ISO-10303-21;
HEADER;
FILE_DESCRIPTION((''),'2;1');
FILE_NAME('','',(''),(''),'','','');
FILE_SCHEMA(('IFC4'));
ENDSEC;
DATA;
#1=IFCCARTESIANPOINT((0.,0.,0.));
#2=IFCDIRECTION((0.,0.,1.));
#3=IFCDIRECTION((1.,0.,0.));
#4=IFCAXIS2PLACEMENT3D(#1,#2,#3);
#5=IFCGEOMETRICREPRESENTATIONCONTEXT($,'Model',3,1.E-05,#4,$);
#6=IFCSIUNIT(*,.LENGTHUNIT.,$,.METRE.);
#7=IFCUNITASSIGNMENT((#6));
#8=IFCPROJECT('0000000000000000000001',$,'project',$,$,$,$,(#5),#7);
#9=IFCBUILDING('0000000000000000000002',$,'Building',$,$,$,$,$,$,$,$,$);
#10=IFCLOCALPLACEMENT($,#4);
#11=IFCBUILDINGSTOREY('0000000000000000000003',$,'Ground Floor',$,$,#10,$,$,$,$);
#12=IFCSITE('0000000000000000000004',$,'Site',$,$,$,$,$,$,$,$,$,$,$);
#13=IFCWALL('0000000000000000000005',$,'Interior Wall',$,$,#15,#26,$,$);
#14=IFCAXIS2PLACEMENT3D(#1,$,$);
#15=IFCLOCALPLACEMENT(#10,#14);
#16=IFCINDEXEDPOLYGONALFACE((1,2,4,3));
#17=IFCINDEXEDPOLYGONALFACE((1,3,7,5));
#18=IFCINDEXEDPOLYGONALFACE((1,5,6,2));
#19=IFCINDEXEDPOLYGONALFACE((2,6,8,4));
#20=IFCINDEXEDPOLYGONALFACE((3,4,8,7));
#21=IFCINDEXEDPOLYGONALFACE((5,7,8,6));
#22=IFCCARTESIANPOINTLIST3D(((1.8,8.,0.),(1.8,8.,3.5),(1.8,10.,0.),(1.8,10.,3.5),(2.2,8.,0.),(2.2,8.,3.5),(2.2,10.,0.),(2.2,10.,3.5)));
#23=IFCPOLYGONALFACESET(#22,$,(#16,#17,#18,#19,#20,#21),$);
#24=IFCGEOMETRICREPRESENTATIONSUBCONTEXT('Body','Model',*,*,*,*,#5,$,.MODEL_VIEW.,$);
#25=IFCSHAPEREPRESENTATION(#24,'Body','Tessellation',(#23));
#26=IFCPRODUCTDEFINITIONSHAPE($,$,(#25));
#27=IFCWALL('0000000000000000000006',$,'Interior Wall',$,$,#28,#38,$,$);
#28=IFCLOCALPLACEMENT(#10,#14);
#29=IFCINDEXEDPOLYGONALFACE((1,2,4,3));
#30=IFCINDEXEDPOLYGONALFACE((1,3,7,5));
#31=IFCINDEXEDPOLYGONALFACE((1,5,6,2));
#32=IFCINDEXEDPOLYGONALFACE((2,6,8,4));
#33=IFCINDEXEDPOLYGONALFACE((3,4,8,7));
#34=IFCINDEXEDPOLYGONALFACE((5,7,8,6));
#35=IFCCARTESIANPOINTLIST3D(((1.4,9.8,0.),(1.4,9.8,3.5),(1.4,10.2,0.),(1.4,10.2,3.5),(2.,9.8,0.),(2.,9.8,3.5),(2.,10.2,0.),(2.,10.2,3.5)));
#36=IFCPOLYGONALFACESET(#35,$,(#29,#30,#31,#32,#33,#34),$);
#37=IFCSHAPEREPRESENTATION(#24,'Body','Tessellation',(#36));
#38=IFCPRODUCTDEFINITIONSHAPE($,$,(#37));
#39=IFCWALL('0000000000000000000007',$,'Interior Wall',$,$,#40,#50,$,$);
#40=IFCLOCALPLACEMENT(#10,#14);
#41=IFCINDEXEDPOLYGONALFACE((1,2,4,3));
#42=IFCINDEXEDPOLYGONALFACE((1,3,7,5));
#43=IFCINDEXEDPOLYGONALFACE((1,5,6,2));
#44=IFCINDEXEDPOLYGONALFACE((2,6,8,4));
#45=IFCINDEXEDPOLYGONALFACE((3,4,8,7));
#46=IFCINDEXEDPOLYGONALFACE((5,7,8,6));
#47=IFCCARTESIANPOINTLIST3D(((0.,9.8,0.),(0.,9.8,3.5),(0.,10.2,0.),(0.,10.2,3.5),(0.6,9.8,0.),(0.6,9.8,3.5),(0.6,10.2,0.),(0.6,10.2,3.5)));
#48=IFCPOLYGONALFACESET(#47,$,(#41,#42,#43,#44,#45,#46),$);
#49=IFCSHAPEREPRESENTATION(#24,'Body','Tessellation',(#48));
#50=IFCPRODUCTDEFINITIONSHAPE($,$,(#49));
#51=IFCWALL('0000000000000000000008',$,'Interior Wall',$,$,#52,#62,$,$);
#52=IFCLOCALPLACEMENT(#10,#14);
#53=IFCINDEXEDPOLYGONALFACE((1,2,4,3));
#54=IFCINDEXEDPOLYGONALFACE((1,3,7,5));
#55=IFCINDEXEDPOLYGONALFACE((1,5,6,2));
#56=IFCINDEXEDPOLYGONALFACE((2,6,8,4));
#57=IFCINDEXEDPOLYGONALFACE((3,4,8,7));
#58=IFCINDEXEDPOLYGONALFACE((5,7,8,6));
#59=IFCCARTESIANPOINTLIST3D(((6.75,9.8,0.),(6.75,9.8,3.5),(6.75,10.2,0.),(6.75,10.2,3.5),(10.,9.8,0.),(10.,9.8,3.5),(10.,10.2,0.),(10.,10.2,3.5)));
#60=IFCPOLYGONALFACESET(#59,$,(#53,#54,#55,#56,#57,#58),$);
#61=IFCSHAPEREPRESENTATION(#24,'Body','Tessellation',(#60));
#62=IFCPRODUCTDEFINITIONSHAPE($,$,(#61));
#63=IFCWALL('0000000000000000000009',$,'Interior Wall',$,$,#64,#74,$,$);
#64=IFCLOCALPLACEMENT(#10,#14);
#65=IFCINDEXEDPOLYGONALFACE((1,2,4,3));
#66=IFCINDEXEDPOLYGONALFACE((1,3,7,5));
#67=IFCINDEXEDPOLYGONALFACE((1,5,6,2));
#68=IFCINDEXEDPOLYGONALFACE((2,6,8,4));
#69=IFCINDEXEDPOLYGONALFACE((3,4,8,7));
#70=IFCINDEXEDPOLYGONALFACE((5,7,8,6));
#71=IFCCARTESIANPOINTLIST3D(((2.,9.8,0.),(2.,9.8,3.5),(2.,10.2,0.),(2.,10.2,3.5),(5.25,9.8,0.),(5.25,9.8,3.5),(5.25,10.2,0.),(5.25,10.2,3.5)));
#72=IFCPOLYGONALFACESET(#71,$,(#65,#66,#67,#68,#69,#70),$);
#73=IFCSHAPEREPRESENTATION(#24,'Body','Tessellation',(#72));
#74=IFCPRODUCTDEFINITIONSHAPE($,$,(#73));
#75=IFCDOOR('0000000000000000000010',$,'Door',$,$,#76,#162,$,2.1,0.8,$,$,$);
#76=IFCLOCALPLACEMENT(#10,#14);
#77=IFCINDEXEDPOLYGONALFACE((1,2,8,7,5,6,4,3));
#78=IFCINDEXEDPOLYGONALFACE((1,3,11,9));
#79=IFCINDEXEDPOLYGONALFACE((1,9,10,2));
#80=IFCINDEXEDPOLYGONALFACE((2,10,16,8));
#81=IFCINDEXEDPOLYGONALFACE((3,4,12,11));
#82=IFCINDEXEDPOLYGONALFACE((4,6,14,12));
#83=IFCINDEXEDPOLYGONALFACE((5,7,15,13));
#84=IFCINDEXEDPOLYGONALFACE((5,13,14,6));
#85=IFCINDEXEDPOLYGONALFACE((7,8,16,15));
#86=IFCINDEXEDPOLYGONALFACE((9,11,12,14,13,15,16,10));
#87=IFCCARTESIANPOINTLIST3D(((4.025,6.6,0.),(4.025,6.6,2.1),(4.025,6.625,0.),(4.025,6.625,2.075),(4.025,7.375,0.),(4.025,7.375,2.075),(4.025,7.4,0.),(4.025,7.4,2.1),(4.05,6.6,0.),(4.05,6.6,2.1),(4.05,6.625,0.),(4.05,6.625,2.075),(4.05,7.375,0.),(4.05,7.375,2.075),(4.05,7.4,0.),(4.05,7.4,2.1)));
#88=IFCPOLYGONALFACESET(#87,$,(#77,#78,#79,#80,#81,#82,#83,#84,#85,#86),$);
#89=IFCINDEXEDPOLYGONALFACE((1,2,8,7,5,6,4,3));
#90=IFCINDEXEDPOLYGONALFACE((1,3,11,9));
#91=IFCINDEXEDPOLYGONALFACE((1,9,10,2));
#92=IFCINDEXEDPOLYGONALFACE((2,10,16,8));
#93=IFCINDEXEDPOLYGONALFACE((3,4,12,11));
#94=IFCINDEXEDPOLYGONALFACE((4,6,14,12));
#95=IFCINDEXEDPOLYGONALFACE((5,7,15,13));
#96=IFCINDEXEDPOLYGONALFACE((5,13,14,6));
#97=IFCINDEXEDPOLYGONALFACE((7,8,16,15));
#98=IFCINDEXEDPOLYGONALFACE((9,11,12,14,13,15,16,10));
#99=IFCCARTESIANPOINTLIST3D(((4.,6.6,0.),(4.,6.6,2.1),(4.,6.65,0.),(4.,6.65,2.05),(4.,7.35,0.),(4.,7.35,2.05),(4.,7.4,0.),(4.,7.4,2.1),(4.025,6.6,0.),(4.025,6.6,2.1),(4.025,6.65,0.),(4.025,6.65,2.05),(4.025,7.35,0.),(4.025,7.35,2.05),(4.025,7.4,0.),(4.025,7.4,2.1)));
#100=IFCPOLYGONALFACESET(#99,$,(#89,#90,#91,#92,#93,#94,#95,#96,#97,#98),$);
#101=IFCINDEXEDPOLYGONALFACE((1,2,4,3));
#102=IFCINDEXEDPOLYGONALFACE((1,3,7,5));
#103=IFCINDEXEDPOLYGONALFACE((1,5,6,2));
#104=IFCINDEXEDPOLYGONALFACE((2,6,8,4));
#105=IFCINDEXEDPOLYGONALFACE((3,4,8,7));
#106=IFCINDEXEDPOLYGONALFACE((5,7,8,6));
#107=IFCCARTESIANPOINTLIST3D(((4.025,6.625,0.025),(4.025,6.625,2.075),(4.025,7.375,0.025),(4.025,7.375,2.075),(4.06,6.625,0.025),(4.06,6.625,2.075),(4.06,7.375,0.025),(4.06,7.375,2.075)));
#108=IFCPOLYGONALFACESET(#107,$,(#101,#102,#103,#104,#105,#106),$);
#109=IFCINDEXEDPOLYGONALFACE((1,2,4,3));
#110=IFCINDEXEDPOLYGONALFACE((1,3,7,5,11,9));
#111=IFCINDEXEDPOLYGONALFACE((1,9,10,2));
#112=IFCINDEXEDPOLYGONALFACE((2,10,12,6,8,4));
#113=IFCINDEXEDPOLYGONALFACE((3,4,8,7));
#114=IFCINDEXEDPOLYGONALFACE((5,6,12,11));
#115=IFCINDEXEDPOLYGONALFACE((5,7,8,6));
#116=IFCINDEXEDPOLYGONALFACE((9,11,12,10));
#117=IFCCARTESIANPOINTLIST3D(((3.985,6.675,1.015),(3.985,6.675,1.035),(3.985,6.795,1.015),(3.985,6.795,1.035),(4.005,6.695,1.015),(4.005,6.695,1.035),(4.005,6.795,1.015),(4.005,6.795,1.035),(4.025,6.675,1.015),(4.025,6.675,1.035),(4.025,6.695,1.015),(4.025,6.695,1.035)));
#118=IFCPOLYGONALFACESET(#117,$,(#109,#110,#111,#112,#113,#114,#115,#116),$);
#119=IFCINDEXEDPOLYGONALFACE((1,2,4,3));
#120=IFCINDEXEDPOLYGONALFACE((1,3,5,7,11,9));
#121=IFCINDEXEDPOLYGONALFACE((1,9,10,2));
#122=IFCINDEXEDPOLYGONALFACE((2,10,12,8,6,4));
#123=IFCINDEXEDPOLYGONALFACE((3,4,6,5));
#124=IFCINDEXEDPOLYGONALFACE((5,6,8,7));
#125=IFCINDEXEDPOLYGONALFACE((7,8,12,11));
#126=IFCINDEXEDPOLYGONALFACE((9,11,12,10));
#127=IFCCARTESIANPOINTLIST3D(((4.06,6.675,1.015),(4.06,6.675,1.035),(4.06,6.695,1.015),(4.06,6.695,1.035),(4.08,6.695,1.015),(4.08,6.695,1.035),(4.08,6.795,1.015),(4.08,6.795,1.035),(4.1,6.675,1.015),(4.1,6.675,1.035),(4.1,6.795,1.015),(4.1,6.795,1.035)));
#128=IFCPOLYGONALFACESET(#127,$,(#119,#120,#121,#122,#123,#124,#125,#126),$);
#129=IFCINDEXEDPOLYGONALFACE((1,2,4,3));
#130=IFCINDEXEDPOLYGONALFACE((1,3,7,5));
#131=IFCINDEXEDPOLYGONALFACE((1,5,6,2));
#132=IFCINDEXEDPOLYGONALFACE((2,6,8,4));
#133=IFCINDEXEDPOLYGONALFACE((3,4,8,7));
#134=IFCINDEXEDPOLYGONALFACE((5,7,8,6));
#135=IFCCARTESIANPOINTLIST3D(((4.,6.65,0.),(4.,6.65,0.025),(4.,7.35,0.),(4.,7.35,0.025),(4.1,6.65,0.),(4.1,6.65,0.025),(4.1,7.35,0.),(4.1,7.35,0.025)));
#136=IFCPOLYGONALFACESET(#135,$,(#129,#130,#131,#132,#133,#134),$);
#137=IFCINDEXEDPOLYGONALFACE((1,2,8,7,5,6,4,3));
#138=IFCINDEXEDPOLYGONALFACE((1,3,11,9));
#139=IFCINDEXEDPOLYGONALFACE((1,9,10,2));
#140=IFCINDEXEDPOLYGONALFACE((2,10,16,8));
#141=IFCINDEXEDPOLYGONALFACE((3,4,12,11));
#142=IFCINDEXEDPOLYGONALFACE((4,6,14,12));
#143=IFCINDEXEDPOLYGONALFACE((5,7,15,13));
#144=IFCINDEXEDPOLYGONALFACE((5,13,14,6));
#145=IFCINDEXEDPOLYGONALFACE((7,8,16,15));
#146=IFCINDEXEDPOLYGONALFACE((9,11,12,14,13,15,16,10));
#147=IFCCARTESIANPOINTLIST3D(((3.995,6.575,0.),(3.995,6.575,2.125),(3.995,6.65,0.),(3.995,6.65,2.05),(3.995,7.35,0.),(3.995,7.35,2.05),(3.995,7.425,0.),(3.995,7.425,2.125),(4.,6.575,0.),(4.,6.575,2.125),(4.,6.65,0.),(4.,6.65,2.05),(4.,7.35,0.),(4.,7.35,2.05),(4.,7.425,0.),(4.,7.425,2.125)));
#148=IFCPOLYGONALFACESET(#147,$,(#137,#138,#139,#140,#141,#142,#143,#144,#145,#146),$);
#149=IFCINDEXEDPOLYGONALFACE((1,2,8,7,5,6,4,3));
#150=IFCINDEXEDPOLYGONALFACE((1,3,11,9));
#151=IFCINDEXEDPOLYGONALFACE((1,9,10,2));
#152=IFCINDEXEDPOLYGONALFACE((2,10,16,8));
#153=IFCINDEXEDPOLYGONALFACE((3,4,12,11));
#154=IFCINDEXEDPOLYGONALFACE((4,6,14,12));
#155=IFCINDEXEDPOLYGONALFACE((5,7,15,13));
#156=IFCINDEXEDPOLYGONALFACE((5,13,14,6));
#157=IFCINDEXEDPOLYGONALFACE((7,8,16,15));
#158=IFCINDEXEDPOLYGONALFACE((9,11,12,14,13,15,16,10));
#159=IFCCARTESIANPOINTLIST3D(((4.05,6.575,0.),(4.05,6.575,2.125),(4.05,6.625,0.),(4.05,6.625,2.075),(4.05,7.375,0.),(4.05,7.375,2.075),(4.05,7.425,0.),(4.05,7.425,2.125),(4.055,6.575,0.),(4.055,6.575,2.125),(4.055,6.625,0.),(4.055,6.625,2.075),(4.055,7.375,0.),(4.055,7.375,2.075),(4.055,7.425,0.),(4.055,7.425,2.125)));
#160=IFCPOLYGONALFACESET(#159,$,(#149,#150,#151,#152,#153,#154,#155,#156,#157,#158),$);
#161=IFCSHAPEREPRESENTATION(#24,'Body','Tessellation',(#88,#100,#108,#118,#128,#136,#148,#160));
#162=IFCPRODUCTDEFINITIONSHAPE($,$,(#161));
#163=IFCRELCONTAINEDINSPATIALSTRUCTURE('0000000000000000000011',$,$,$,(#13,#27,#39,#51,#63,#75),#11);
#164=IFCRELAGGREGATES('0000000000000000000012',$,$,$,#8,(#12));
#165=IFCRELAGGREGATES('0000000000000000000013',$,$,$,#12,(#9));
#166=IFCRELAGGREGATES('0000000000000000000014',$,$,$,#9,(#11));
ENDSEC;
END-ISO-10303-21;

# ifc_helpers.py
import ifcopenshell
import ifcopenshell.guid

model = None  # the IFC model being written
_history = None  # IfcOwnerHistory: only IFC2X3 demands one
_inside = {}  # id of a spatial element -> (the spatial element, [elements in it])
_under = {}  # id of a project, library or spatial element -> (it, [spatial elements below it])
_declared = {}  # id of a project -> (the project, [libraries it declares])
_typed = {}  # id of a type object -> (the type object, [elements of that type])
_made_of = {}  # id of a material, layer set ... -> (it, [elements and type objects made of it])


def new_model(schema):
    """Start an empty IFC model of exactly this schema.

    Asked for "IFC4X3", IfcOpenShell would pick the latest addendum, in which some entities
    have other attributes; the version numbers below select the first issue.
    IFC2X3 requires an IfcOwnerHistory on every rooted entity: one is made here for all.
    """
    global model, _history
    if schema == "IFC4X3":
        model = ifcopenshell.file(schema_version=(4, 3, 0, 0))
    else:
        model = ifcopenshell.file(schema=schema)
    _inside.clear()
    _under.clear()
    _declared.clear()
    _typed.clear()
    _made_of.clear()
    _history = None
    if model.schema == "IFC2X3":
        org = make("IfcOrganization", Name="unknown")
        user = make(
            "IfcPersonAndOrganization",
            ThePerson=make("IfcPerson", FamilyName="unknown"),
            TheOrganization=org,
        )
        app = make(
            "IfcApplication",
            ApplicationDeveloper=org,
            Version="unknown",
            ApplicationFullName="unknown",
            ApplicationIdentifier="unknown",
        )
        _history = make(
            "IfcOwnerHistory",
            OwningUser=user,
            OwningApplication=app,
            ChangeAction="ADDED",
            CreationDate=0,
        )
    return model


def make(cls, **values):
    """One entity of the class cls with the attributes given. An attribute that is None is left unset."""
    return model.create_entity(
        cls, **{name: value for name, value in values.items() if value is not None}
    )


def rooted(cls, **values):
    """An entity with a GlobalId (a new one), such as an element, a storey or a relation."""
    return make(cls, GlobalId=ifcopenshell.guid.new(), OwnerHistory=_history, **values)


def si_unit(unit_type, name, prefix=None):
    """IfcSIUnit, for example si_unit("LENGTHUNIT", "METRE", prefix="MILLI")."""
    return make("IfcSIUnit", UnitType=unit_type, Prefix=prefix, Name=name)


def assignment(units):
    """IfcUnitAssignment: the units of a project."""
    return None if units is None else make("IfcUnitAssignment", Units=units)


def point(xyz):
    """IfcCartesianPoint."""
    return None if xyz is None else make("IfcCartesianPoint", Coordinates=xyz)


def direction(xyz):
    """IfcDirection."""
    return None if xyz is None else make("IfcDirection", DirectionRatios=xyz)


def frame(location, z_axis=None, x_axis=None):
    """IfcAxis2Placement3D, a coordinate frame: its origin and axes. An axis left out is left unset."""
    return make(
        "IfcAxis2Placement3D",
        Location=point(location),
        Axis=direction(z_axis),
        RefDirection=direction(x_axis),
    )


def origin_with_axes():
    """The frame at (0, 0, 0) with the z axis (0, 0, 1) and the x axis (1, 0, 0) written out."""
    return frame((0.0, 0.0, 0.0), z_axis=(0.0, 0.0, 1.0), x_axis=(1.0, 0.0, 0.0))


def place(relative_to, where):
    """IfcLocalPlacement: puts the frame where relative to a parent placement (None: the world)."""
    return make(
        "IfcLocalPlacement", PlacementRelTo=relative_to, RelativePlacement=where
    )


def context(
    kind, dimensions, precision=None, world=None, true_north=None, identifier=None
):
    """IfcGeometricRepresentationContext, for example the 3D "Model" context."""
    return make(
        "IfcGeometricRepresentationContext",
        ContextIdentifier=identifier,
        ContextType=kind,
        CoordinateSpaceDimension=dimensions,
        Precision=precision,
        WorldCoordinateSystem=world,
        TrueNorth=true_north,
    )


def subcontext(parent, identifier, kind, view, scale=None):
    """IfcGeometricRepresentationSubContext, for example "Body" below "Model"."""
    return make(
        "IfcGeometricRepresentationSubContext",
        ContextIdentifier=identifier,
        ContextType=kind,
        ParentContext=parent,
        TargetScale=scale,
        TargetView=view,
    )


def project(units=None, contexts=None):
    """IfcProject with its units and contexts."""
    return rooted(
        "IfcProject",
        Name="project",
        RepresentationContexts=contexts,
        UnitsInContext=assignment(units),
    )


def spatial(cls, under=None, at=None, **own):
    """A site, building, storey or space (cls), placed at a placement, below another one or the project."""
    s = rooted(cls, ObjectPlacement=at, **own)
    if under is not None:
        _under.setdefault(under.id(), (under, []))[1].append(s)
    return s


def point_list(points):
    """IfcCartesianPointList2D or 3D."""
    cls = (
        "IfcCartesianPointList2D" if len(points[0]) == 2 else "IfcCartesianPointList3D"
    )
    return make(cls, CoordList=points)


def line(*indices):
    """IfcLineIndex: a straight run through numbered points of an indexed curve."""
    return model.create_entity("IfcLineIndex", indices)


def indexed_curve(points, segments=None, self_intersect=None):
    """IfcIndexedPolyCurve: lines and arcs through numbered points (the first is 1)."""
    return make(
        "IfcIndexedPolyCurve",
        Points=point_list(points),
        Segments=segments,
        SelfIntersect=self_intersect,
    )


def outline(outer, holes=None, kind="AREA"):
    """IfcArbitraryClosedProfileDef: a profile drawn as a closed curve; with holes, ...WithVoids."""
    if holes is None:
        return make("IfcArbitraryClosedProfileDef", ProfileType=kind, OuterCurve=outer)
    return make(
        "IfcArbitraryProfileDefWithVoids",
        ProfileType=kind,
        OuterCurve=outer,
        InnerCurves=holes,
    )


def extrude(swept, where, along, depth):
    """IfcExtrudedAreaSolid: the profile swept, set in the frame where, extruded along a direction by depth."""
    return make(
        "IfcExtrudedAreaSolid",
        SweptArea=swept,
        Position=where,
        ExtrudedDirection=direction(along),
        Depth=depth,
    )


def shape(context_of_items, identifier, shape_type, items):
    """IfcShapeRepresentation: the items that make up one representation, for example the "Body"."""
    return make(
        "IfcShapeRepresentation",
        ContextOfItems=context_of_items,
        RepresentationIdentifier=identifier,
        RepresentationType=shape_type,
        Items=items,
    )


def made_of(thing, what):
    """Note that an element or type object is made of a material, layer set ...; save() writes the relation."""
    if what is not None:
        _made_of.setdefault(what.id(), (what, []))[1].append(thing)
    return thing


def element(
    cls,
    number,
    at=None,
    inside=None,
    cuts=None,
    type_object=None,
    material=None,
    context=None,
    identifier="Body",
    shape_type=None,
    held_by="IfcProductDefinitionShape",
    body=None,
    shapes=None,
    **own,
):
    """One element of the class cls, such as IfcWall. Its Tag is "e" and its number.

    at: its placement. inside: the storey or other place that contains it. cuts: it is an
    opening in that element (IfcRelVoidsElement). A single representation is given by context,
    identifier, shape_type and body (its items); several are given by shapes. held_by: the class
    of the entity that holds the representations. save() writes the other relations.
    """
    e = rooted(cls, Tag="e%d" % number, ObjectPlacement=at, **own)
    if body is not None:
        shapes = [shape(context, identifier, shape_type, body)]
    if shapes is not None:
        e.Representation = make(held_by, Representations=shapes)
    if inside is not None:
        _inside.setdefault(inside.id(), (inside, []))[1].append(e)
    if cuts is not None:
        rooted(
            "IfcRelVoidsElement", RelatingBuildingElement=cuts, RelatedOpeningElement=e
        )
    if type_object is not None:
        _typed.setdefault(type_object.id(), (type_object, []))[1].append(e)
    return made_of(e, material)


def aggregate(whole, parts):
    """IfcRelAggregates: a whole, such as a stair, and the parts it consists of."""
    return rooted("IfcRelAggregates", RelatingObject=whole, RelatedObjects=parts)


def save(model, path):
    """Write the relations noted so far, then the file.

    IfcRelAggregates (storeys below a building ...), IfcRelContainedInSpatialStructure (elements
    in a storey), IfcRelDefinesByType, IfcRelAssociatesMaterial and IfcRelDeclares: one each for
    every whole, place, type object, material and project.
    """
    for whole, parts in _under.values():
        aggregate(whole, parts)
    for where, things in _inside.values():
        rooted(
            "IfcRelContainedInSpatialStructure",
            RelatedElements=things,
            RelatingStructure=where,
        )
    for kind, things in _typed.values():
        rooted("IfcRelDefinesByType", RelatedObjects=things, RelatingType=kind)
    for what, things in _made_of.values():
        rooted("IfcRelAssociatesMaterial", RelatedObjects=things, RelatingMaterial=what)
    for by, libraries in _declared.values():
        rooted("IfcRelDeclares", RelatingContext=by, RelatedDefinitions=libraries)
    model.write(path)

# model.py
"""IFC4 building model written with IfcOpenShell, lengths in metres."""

from ifc_helpers import new_model, si_unit, frame, origin_with_axes, place, context, subcontext, project, spatial, line, indexed_curve, outline, extrude, element, save


model = new_model("IFC4")

# Units and contexts
model_context = context("Model", 3, precision=1e-05, world=origin_with_axes())
body_context = subcontext(model_context, "Body", "Model", "MODEL_VIEW")
ifc_project = project(units=[si_unit("LENGTHUNIT", "METRE")], contexts=[model_context])

# Site, building, storey
site = spatial("IfcSite", under=ifc_project, Name="Site")
building = spatial("IfcBuilding", under=site, Name="Building")
storey_placement = place(None, origin_with_axes())
storey = spatial("IfcBuildingStorey", under=building, at=storey_placement, Name="Ground Floor")

# Walls
wall_1_placement = place(storey_placement, frame((2.0, 8.0, 0.0), z_axis=(0.0, 0.0, 1.0), x_axis=(0.0, 1.0, 0.0)))
element("IfcWall", 1, at=wall_1_placement, inside=storey, Name="Interior Wall", context=body_context, shape_type="SweptSolid", body=[
    extrude(outline(indexed_curve([(0.0, 0.0), (0.0, 0.4), (2.0, 0.4), (2.0, 0.0), (0.0, 0.0)], self_intersect=False)), frame((0.0, -0.2, 0.0), z_axis=(0.0, 0.0, 1.0), x_axis=(1.0, 0.0, 0.0)), (0.0, 0.0, 1.0), 3.5),
])
for number, where, z_axis, x_axis, name in (
    (2, (2.0, 10.0, 0.0), (0.0, 0.0, 1.0), (-1.0, 0.0, 0.0), "Interior Wall"),
    (3, (0.6, 10.0, 0.0), (0.0, 0.0, 1.0), (-1.0, 0.0, 0.0), "Interior Wall"),
):
    element("IfcWall", number, at=place(storey_placement, frame(where, z_axis=z_axis, x_axis=x_axis)), inside=storey, Name=name, context=body_context, shape_type="SweptSolid", body=[
        extrude(outline(indexed_curve([(0.0, 0.0), (0.0, 0.4), (0.6, 0.4), (0.6, 0.0), (0.0, 0.0)], self_intersect=False)), frame((0.0, -0.2, 0.0), z_axis=(0.0, 0.0, 1.0), x_axis=(1.0, 0.0, 0.0)), (0.0, 0.0, 1.0), 3.5),
    ])
for number, where, z_axis, x_axis, name in (
    (4, (10.0, 10.0, 0.0), (0.0, 0.0, 1.0), (-1.0, 0.0, 0.0), "Interior Wall"),
    (5, (5.25, 10.0, 0.0), (0.0, 0.0, 1.0), (-1.0, 0.0, 0.0), "Interior Wall"),
):
    element("IfcWall", number, at=place(storey_placement, frame(where, z_axis=z_axis, x_axis=x_axis)), inside=storey, Name=name, context=body_context, shape_type="SweptSolid", body=[
        extrude(outline(indexed_curve([(0.0, 0.0), (0.0, 0.4), (3.25, 0.4), (3.25, 0.0), (0.0, 0.0)], self_intersect=False)), frame((0.0, -0.2, 0.0), z_axis=(0.0, 0.0, 1.0), x_axis=(1.0, 0.0, 0.0)), (0.0, 0.0, 1.0), 3.5),
    ])

# Door
door_1_placement = place(storey_placement, frame((4.0, 7.4, 0.0), z_axis=(0.0, 0.0, 1.0), x_axis=(0.0, -1.0, 0.0)))
element("IfcDoor", 6, at=door_1_placement, inside=storey, Name="Door", OverallHeight=2.1, OverallWidth=0.8, context=body_context, shape_type="SweptSolid", body=[
    extrude(outline(indexed_curve([(0.0, 0.0), (0.0, 2.1), (0.8, 2.1), (0.8, 0.0), (0.775, 0.0), (0.775, 2.075), (0.025, 2.075), (0.025, 0.0)], segments=[line(1, 2, 3, 4, 5, 6, 7, 8, 1)])), frame((0.0, 0.025, 0.0), z_axis=(0.0, -1.0, 0.0), x_axis=(1.0, 0.0, 0.0)), (0.0, 0.0, -1.0), 0.025),
    extrude(outline(indexed_curve([(0.0, 0.0), (0.0, 2.1), (0.8, 2.1), (0.8, 0.0), (0.75, 0.0), (0.75, 2.05), (0.05, 2.05), (0.05, 0.0)], segments=[line(1, 2, 3, 4, 5, 6, 7, 8, 1)])), frame((0.0, 0.0, 0.0), z_axis=(0.0, -1.0, 0.0), x_axis=(1.0, 0.0, 0.0)), (0.0, 0.0, -1.0), 0.025),
    extrude(outline(indexed_curve([(0.0, 0.0), (0.75, 0.0), (0.75, 0.035), (0.0, 0.035)], segments=[line(1, 2, 3, 4, 1)])), frame((0.025, 0.025, 0.025), z_axis=(0.0, 0.0, 1.0), x_axis=(1.0, 0.0, 0.0)), (0.0, 0.0, 1.0), 2.05),
    extrude(outline(indexed_curve([(0.0, 0.0), (0.0, -0.04), (-0.12, -0.04), (-0.12, -0.02), (-0.02, -0.02), (-0.02, 0.0)], segments=[line(1, 2, 3, 4, 5, 6, 1)])), frame((0.725, 0.025, 1.015), z_axis=(0.0, 0.0, 1.0), x_axis=(1.0, 0.0, 0.0)), (0.0, 0.0, 1.0), 0.02),
    extrude(outline(indexed_curve([(0.0, 0.0), (0.0, 0.04), (-0.12, 0.04), (-0.12, 0.02), (-0.02, 0.02), (-0.02, 0.0)], segments=[line(1, 2, 3, 4, 5, 6, 1)])), frame((0.725, 0.06, 1.015), z_axis=(0.0, 0.0, 1.0), x_axis=(1.0, 0.0, 0.0)), (0.0, 0.0, 1.0), 0.02),
    extrude(outline(indexed_curve([(0.0, 0.0), (0.7, 0.0), (0.7, 0.1), (0.0, 0.1)], segments=[line(1, 2, 3, 4, 1)])), frame((0.05, 0.0, 0.0), z_axis=(0.0, 0.0, 1.0), x_axis=(1.0, 0.0, 0.0)), (0.0, 0.0, 1.0), 0.025),
    extrude(outline(indexed_curve([(0.0, 0.0), (0.0, 2.125), (0.85, 2.125), (0.85, 0.0), (0.775, 0.0), (0.775, 2.05), (0.075, 2.05), (0.075, 0.0)], segments=[line(1, 2, 3, 4, 5, 6, 7, 8, 1)])), frame((-0.025, -0.005, 0.0), z_axis=(0.0, -1.0, 0.0), x_axis=(1.0, 0.0, 0.0)), (0.0, 0.0, -1.0), 0.005),
    extrude(outline(indexed_curve([(0.0, 0.0), (0.0, 2.125), (0.85, 2.125), (0.85, 0.0), (0.8, 0.0), (0.8, 2.075), (0.05, 2.075), (0.05, 0.0)], segments=[line(1, 2, 3, 4, 5, 6, 7, 8, 1)])), frame((-0.025, 0.05, 0.0), z_axis=(0.0, -1.0, 0.0), x_axis=(1.0, 0.0, 0.0)), (0.0, 0.0, -1.0), 0.005),
])

save(model, "model.ifc")
